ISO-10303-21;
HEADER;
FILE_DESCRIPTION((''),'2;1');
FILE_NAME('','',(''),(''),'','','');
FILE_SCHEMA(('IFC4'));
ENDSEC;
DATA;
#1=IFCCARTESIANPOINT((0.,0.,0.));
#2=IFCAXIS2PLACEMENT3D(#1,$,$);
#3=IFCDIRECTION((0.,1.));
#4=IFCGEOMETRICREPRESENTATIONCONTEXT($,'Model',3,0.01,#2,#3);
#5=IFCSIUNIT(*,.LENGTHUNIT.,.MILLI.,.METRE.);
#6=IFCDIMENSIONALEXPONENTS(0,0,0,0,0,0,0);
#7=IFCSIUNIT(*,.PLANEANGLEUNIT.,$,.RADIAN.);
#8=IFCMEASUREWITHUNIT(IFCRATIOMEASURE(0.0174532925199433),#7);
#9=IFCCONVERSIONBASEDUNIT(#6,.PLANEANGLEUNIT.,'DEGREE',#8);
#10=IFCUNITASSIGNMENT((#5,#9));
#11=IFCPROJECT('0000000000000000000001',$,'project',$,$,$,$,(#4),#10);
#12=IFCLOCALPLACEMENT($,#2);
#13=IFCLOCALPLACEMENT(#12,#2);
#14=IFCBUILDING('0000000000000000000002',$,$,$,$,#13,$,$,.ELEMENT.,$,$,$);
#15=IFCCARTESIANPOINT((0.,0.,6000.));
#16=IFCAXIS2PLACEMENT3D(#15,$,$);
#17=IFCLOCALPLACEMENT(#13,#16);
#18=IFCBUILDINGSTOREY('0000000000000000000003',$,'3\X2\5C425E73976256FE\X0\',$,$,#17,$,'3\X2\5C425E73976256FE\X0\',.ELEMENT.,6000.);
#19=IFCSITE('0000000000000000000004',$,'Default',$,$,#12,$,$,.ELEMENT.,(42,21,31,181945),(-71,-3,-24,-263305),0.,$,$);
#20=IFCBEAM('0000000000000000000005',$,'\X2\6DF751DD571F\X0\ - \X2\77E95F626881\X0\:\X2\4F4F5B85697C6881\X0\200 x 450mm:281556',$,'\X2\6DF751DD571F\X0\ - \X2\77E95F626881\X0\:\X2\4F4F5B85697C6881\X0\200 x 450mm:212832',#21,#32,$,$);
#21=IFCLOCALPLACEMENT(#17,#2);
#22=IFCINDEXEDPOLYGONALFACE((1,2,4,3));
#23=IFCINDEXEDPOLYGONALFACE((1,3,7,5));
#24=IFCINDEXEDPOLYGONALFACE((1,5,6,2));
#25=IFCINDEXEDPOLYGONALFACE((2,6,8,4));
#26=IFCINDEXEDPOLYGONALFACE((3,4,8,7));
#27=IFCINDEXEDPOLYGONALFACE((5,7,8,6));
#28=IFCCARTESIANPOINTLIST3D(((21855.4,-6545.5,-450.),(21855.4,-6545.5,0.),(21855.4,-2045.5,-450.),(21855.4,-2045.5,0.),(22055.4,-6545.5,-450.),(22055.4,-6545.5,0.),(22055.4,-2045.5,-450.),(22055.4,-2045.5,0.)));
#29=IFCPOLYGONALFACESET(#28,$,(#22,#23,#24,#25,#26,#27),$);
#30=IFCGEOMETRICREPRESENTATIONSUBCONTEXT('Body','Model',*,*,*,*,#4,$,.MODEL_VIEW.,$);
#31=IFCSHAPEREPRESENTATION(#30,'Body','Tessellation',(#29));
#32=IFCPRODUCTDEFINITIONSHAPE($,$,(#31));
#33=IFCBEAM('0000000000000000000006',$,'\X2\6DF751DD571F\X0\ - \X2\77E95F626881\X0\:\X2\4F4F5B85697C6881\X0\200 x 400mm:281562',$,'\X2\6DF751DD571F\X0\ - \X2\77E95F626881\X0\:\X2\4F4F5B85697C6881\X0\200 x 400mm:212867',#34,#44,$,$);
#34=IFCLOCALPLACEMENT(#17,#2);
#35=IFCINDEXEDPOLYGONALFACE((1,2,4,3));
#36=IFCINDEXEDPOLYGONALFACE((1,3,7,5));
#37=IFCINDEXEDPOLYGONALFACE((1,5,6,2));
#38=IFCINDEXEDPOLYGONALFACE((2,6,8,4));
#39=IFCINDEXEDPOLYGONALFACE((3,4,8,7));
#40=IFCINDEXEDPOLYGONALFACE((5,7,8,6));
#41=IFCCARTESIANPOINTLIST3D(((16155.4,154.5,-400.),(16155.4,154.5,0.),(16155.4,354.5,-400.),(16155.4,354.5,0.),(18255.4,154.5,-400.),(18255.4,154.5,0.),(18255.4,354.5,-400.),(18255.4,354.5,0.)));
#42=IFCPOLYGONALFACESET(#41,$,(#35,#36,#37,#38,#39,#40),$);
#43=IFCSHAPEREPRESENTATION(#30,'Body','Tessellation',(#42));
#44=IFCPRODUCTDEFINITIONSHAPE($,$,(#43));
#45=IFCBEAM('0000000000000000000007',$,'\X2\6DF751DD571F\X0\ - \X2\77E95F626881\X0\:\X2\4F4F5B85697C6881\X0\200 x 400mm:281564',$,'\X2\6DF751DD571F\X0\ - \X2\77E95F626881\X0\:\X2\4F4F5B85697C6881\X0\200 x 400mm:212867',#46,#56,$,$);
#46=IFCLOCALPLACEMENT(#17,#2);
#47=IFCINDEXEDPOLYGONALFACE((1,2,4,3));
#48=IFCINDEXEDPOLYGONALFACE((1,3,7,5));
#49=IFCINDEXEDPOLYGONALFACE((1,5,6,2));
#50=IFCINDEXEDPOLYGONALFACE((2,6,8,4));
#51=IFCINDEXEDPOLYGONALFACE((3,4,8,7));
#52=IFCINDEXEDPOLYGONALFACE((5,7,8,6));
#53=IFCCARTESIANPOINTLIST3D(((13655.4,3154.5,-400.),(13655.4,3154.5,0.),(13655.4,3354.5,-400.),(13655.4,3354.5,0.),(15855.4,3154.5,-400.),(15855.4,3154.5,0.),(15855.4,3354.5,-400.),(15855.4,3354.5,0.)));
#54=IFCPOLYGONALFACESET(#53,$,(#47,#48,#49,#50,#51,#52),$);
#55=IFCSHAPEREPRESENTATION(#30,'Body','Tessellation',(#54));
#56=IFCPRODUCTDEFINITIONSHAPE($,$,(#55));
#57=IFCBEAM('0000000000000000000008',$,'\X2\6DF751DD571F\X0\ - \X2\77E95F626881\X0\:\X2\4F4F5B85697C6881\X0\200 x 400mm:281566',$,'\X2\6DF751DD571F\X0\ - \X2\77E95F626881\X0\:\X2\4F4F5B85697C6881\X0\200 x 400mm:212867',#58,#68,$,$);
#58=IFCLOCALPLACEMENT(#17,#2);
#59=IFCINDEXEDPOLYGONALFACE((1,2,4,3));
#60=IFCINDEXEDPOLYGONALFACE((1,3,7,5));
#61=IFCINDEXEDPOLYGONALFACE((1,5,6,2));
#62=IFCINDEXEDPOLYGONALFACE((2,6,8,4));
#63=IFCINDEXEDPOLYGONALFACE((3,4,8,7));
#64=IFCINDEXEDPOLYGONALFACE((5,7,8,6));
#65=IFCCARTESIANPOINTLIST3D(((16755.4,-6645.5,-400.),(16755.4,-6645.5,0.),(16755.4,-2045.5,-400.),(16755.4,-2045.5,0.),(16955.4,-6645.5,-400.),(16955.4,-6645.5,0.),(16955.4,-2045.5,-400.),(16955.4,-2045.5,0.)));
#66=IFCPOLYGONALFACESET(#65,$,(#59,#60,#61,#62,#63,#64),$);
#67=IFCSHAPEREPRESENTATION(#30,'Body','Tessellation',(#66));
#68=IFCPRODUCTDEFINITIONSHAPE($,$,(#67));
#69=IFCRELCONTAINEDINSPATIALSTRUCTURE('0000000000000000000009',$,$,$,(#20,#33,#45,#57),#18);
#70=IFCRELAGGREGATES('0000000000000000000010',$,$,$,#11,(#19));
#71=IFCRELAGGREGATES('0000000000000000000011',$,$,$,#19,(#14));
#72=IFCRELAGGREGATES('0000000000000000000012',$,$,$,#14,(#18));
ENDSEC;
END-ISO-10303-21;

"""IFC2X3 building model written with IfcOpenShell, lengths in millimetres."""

from ifc_helpers import new_model, entity, si_unit, converted_unit, direction, frame, frame_2d, origin, origin_2d_with_axis, place, context, subcontext, project, spatial, rectangle, extrude, element, save


model = new_model("IFC2X3")

# Units and contexts
model_context = context("Model", 3, precision=0.01, world=origin(), true_north=direction((0.0, 1.0)))
body_context = subcontext(model_context, "Body", "Model", "MODEL_VIEW")
ifc_project = project(units=[si_unit("LENGTHUNIT", "METRE", prefix="MILLI"), converted_unit("PLANEANGLEUNIT", "DEGREE", entity("IfcRatioMeasure", 0.0174532925199433), si_unit("PLANEANGLEUNIT", "RADIAN"), dimensions=[0, 0, 0, 0, 0, 0, 0])], contexts=[model_context])

# Site, building, storey
site_placement = place(None, origin())
site = spatial("IfcSite", under=ifc_project, at=site_placement, Name="Default", CompositionType="ELEMENT", RefLatitude=(42, 21, 31, 181945), RefLongitude=(-71, -3, -24, -263305), RefElevation=0.0)
building_placement = place(site_placement, origin())
building = spatial("IfcBuilding", under=site, at=building_placement, CompositionType="ELEMENT")
storey_placement = place(building_placement, frame((0.0, 0.0, 6000.0)))
storey = spatial("IfcBuildingStorey", under=building, at=storey_placement, Name="3层平面图", LongName="3层平面图", CompositionType="ELEMENT", Elevation=6000.0)

# Beams
beam_1_placement = place(storey_placement, frame((21955.4, -1945.5, 0.0), z_axis=(0.0, 0.0, 1.0), x_axis=(0.0, -1.0, 0.0)))
element("IfcBeam", 1, at=beam_1_placement, inside=storey, Name="混凝土 - 矩形梁:住宅楼梁200 x 450mm:281556", ObjectType="混凝土 - 矩形梁:住宅楼梁200 x 450mm:212832", context=body_context, shape_type="SweptSolid", body=[
    extrude(rectangle(XDim=450.0, YDim=200.0, at=frame_2d((0.0, 0.0), x_axis=(1.0, 0.0))), frame((100.0, 0.0, -225.0), z_axis=(1.0, 0.0, 0.0), x_axis=(0.0, 0.0, -1.0)), (0.0, 0.0, 1.0), 4500.0),
])
beam_2_placement = place(storey_placement, frame((18355.4, 254.5, 0.0), z_axis=(0.0, 0.0, 1.0), x_axis=(-1.0, 0.0, 0.0)))
element("IfcBeam", 2, at=beam_2_placement, inside=storey, Name="混凝土 - 矩形梁:住宅楼梁200 x 400mm:281562", ObjectType="混凝土 - 矩形梁:住宅楼梁200 x 400mm:212867", context=body_context, shape_type="SweptSolid", body=[
    extrude(rectangle(XDim=400.0, YDim=200.0, at=frame_2d((0.0, 0.0), x_axis=(1.0, 0.0))), frame((100.0, 0.0, -200.0), z_axis=(1.0, 0.0, 0.0), x_axis=(0.0, 0.0, -1.0)), (0.0, 0.0, 1.0), 2100.0),
])
beam_3_placement = place(storey_placement, frame((16055.4, 3254.5, 0.0), z_axis=(0.0, 0.0, 1.0), x_axis=(-1.0, 0.0, 0.0)))
element("IfcBeam", 3, at=beam_3_placement, inside=storey, Name="混凝土 - 矩形梁:住宅楼梁200 x 400mm:281564", ObjectType="混凝土 - 矩形梁:住宅楼梁200 x 400mm:212867", context=body_context, shape_type="SweptSolid", body=[
    extrude(rectangle(XDim=400.0, YDim=200.0, at=frame_2d((0.0, 0.0), x_axis=(1.0, 0.0))), frame((200.0, 0.0, -200.0), z_axis=(1.0, 0.0, 0.0), x_axis=(0.0, 0.0, -1.0)), (0.0, 0.0, 1.0), 2200.0),
])
beam_4_placement = place(storey_placement, frame((16855.4, -1945.5, 0.0), z_axis=(0.0, 0.0, 1.0), x_axis=(0.0, -1.0, 0.0)))
element("IfcBeam", 4, at=beam_4_placement, inside=storey, Name="混凝土 - 矩形梁:住宅楼梁200 x 400mm:281566", ObjectType="混凝土 - 矩形梁:住宅楼梁200 x 400mm:212867", context=body_context, shape_type="SweptSolid", body=[
    extrude(rectangle(XDim=400.0, YDim=200.0, at=origin_2d_with_axis()), frame((100.0, 0.0, -200.0), z_axis=(1.0, 0.0, 0.0), x_axis=(0.0, 0.0, -1.0)), (0.0, 0.0, 1.0), 4600.0),
])

save(model, "model.ifc")
